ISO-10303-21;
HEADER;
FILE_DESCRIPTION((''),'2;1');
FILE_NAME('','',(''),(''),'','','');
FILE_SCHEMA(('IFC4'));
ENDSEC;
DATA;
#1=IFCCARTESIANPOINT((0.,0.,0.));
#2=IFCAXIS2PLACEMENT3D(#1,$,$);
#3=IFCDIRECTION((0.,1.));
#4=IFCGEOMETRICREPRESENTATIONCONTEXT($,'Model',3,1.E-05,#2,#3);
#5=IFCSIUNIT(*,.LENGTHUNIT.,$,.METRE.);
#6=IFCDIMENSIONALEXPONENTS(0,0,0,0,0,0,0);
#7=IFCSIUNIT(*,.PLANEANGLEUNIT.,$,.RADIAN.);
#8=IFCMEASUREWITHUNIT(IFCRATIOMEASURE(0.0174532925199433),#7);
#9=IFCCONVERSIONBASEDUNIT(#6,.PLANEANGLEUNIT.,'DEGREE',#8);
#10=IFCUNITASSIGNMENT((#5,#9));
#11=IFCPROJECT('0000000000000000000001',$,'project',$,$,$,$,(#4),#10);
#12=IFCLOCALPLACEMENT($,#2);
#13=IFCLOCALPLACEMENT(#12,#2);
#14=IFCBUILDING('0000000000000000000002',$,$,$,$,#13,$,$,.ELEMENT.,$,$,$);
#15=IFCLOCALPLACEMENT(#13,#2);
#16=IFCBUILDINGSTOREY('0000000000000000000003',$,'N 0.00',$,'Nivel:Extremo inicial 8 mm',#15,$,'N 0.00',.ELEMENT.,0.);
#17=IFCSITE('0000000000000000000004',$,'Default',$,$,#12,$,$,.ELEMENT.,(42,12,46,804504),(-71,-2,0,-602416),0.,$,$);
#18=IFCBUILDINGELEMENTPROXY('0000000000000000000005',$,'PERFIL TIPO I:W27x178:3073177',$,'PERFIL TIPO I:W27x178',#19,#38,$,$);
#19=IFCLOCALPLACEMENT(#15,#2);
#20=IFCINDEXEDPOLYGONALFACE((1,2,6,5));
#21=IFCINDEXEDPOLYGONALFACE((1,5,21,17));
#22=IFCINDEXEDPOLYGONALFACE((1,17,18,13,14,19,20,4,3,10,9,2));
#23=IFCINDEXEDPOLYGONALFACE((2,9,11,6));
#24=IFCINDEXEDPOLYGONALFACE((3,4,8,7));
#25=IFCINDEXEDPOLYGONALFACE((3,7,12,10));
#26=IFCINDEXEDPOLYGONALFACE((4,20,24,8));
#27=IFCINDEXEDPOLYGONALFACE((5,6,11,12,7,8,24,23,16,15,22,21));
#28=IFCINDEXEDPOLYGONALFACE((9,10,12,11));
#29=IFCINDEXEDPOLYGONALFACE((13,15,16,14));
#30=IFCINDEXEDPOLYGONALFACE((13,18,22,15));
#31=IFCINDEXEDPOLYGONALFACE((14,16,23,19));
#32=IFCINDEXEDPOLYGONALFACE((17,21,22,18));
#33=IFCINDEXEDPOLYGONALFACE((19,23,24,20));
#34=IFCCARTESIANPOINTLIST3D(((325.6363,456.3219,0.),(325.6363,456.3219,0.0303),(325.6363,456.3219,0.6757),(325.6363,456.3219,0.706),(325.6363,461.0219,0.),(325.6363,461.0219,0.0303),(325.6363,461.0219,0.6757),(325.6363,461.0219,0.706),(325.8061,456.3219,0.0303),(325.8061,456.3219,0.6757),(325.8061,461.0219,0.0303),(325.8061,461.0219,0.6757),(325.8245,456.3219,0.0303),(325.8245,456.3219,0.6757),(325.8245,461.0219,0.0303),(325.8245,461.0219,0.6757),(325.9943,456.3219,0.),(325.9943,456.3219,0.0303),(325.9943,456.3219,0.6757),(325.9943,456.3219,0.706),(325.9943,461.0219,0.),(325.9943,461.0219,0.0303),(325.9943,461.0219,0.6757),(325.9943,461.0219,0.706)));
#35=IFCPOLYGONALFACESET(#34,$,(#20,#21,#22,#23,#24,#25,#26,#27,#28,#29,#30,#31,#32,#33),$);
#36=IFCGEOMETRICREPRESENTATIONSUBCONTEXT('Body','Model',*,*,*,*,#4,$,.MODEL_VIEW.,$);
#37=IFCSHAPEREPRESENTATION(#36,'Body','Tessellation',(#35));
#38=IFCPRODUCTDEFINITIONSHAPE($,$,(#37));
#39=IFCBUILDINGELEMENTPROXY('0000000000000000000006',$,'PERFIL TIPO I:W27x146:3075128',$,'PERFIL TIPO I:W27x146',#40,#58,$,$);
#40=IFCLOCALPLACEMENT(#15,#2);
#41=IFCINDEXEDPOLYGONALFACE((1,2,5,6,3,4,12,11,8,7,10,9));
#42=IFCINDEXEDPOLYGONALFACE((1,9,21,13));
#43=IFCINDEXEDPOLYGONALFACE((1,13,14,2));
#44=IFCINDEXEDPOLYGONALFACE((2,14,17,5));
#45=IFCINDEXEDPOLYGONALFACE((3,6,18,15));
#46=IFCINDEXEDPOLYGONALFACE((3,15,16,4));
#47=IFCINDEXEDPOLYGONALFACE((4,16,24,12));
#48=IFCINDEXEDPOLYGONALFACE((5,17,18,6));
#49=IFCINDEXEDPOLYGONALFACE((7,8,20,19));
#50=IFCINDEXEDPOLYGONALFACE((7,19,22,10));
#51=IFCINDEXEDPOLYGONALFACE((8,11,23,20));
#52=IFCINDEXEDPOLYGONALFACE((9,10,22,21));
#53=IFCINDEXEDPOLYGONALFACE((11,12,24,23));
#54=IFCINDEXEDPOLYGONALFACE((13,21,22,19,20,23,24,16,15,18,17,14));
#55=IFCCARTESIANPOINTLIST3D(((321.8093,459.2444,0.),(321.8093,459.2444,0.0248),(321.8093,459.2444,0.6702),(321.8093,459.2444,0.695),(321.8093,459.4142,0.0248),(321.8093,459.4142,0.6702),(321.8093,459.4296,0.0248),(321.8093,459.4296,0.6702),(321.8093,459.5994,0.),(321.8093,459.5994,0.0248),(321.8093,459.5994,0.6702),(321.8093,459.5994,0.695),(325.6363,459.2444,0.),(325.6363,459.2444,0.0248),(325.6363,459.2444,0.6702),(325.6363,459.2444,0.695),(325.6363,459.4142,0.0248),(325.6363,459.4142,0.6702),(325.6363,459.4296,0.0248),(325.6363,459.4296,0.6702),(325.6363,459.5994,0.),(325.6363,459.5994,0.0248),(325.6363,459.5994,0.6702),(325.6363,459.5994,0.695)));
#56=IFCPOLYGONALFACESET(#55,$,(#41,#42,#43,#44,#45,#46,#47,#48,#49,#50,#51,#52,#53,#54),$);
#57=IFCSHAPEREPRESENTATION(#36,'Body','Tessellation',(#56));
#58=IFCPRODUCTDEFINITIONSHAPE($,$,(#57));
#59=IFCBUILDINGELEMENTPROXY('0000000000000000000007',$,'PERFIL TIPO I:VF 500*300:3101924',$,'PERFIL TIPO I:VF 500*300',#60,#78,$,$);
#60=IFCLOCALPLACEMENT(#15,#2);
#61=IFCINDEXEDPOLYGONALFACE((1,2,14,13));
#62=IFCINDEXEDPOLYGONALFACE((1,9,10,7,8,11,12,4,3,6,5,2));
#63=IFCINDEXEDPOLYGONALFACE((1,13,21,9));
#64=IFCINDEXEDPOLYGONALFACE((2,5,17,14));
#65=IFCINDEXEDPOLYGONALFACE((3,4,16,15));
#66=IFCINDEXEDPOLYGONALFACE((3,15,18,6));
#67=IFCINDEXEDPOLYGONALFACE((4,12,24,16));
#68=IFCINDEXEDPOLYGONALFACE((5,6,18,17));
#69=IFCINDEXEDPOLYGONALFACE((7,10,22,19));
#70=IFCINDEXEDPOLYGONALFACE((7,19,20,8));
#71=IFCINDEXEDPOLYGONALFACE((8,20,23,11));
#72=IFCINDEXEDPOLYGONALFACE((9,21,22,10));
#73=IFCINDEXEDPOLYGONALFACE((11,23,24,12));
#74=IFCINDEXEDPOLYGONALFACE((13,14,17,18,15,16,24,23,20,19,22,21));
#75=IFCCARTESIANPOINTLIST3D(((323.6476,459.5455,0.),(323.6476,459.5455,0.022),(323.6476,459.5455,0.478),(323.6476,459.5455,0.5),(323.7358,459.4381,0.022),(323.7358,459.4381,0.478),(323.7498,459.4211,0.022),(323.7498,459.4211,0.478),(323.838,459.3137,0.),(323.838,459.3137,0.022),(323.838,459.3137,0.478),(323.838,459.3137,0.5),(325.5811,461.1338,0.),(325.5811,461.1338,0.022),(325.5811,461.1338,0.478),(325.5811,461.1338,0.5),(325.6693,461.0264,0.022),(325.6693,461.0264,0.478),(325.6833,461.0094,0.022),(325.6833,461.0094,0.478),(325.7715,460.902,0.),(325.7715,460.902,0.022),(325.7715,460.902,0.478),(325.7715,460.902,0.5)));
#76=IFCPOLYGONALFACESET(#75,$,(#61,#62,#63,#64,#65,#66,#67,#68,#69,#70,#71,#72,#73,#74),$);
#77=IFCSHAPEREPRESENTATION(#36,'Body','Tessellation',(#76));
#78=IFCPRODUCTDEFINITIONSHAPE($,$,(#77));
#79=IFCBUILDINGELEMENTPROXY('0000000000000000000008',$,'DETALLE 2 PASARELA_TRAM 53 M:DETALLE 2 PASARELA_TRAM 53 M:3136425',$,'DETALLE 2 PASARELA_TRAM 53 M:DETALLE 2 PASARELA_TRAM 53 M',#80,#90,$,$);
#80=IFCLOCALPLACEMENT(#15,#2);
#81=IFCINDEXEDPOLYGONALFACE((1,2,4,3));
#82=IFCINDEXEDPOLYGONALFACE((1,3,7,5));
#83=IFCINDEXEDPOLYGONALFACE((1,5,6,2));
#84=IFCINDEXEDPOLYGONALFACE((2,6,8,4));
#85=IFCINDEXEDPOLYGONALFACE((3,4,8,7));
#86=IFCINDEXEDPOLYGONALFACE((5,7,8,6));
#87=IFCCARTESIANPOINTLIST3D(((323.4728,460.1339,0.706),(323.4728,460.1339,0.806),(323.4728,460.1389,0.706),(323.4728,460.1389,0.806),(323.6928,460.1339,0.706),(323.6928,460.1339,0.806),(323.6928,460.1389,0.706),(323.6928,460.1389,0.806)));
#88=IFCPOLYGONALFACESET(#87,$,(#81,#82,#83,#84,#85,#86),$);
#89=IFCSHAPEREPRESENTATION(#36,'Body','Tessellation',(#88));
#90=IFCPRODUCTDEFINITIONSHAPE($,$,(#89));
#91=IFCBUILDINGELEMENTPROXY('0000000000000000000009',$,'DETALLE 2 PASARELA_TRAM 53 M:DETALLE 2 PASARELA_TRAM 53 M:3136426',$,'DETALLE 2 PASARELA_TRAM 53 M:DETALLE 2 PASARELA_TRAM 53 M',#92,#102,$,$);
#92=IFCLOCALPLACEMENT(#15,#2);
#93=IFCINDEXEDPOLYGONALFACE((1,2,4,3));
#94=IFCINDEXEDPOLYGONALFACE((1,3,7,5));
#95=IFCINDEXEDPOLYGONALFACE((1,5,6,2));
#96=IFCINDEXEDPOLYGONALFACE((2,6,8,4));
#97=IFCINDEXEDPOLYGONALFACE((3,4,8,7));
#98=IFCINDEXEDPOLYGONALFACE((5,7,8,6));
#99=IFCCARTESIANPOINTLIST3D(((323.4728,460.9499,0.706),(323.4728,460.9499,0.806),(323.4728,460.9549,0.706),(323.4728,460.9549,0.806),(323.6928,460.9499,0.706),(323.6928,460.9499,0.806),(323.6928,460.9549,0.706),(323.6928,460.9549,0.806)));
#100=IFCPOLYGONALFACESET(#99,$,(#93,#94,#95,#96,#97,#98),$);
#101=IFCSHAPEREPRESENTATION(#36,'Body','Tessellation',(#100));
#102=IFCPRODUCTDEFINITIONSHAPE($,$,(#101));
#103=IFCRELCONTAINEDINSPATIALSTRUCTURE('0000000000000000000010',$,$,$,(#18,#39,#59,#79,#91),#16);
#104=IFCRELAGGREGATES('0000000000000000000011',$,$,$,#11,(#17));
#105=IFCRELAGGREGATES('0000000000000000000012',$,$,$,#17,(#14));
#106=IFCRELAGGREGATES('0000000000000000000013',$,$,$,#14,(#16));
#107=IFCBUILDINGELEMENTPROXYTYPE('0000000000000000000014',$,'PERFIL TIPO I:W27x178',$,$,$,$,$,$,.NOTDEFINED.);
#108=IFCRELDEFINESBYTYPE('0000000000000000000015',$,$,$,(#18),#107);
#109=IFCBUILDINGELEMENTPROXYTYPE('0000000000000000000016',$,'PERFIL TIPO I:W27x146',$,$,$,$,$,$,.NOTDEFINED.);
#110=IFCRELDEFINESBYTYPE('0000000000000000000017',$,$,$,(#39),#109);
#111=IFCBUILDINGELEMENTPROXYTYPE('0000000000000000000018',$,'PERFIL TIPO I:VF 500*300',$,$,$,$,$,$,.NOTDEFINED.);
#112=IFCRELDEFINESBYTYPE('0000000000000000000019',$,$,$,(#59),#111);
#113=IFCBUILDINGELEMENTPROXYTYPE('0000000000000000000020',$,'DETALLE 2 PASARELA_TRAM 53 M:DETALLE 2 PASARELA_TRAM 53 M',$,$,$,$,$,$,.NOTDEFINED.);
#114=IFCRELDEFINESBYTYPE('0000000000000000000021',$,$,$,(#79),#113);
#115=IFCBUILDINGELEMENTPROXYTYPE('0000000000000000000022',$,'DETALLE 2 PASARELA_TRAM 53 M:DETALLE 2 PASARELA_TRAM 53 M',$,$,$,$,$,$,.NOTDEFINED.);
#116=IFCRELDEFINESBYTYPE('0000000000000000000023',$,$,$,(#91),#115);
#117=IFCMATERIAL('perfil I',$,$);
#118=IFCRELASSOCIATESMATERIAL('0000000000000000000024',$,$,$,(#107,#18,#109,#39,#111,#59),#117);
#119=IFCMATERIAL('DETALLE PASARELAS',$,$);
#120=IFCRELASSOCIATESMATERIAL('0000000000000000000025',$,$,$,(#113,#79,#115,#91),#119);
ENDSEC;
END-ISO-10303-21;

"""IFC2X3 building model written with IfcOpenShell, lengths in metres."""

from ifc_helpers import new_model, entity, si_unit, converted_unit, direction, frame, frame_2d, origin, place, context, subcontext, project, spatial, polyline, rectangle, outline, extrude, source, transform, mapped, material, type_object, type_shapes, element, save


model = new_model("IFC2X3")

# Units and contexts
model_context = context("Model", 3, precision=1e-05, world=origin(), true_north=direction((0.0, 1.0)))
body_context = subcontext(model_context, "Body", "Model", "MODEL_VIEW")
ifc_project = project(units=[si_unit("LENGTHUNIT", "METRE"), converted_unit("PLANEANGLEUNIT", "DEGREE", entity("IfcRatioMeasure", 0.0174532925199433), si_unit("PLANEANGLEUNIT", "RADIAN"), dimensions=[0, 0, 0, 0, 0, 0, 0])], contexts=[model_context])

# Site, building, storey
site_placement = place(None, origin())
site = spatial("IfcSite", under=ifc_project, at=site_placement, Name="Default", CompositionType="ELEMENT", RefLatitude=(42, 12, 46, 804504), RefLongitude=(-71, -2, 0, -602416), RefElevation=0.0)
building_placement = place(site_placement, origin())
building = spatial("IfcBuilding", under=site, at=building_placement, CompositionType="ELEMENT")
storey_placement = place(building_placement, origin())
storey = spatial("IfcBuildingStorey", under=building, at=storey_placement, Name="N 0.00", ObjectType="Nivel:Extremo inicial 8 mm", LongName="N 0.00", CompositionType="ELEMENT", Elevation=0.0)

# Building element proxies
ifc_material_1 = material(Name="perfil I")
building_element_proxy_type_1 = type_object("IfcBuildingElementProxyType", Name="PERFIL TIPO I:W27x178", PredefinedType="NOTDEFINED", material=ifc_material_1)
shared_shape_1 = source(origin(), body_context, "Body", "SweptSolid", [
    extrude(outline(polyline([(-0.179, -0.3227), (-0.179, -0.353), (0.179, -0.353), (0.179, -0.3227), (0.0092, -0.3227), (0.0092, 0.3227), (0.179, 0.3227), (0.179, 0.353), (-0.179, 0.353), (-0.179, 0.3227), (-0.0092, 0.3227), (-0.0092, -0.3227), (-0.179, -0.3227)])), frame((0.0, 0.0, 0.353), z_axis=(-1.0, 0.0, 0.0), x_axis=(0.0, 1.0, 0.0)), (0.0, 0.0, -1.0), 4.7),
])
type_shapes(building_element_proxy_type_1, [shared_shape_1])
proxy_1_placement = place(storey_placement, frame((325.8153, 461.0219, 0.0), z_axis=(0.0, 0.0, 1.0), x_axis=(0.0, -1.0, 0.0)))
element("IfcBuildingElementProxy", 1, at=proxy_1_placement, inside=storey, type_object=building_element_proxy_type_1, material=ifc_material_1, Name="PERFIL TIPO I:W27x178:3073177", ObjectType="PERFIL TIPO I:W27x178", context=body_context, shape_type="MappedRepresentation", body=[
    mapped(shared_shape_1, transform((0.0, 0.0, 0.0), scale=1.0)),
])
building_element_proxy_type_2 = type_object("IfcBuildingElementProxyType", Name="PERFIL TIPO I:W27x146", PredefinedType="NOTDEFINED", material=ifc_material_1)
shared_shape_2 = source(origin(), body_context, "Body", "SweptSolid", [
    extrude(outline(polyline([(0.3227, -0.1775), (0.3475, -0.1775), (0.3475, 0.1775), (0.3227, 0.1775), (0.3227, 0.0077), (-0.3227, 0.0077), (-0.3227, 0.1775), (-0.3475, 0.1775), (-0.3475, -0.1775), (-0.3227, -0.1775), (-0.3227, -0.0077), (0.3227, -0.0077), (0.3227, -0.1775)])), frame((0.0, 0.0, 0.3475), z_axis=(1.0, 0.0, 0.0), x_axis=(0.0, 0.0, 1.0)), (0.0, 0.0, 1.0), 3.827),
])
type_shapes(building_element_proxy_type_2, [shared_shape_2])
proxy_2_placement = place(storey_placement, frame((321.8093, 459.4219, 0.0)))
element("IfcBuildingElementProxy", 2, at=proxy_2_placement, inside=storey, type_object=building_element_proxy_type_2, material=ifc_material_1, Name="PERFIL TIPO I:W27x146:3075128", ObjectType="PERFIL TIPO I:W27x146", context=body_context, shape_type="MappedRepresentation", body=[
    mapped(shared_shape_2, transform((0.0, 0.0, 0.0), scale=1.0)),
])
building_element_proxy_type_3 = type_object("IfcBuildingElementProxyType", Name="PERFIL TIPO I:VF 500*300", PredefinedType="NOTDEFINED", material=ifc_material_1)
shared_shape_3 = source(origin(), body_context, "Body", "SweptSolid", [
    extrude(outline(polyline([(0.228, -0.15), (0.25, -0.15), (0.25, 0.15), (0.228, 0.15), (0.228, 0.011), (-0.228, 0.011), (-0.228, 0.15), (-0.25, 0.15), (-0.25, -0.15), (-0.228, -0.15), (-0.228, -0.011), (0.228, -0.011), (0.228, -0.15)])), frame((0.0, 0.0, 0.25), z_axis=(1.0, 0.0, 0.0), x_axis=(0.0, 0.0, 1.0)), (0.0, 0.0, 1.0), 2.5022),
])
type_shapes(building_element_proxy_type_3, [shared_shape_3])
proxy_3_placement = place(storey_placement, frame((323.7428, 459.4296, 0.0), z_axis=(0.0, 0.0, 1.0), x_axis=(0.772718, 0.63475, 0.0)))
element("IfcBuildingElementProxy", 3, at=proxy_3_placement, inside=storey, type_object=building_element_proxy_type_3, material=ifc_material_1, Name="PERFIL TIPO I:VF 500*300:3101924", ObjectType="PERFIL TIPO I:VF 500*300", context=body_context, shape_type="MappedRepresentation", body=[
    mapped(shared_shape_3, transform((0.0, 0.0, 0.0), scale=1.0)),
])
ifc_material_2 = material(Name="DETALLE PASARELAS")
building_element_proxy_type_4 = type_object("IfcBuildingElementProxyType", Name="DETALLE 2 PASARELA_TRAM 53 M:DETALLE 2 PASARELA_TRAM 53 M", PredefinedType="NOTDEFINED", material=ifc_material_2)
shared_shape_4 = source(origin(), body_context, "Body", "SweptSolid", [
    extrude(rectangle(XDim=0.22, YDim=0.005, at=frame_2d((0.0, 0.0), x_axis=(1.0, 0.0))), frame((0.11, 0.0475, 0.0), z_axis=(0.0, 0.0, 1.0), x_axis=(-1.0, 0.0, 0.0)), (0.0, 0.0, 1.0), 0.1),
])
type_shapes(building_element_proxy_type_4, [shared_shape_4])
proxy_4_placement = place(storey_placement, frame((323.4728, 460.0889, 0.706)))
element("IfcBuildingElementProxy", 4, at=proxy_4_placement, inside=storey, type_object=building_element_proxy_type_4, material=ifc_material_2, Name="DETALLE 2 PASARELA_TRAM 53 M:DETALLE 2 PASARELA_TRAM 53 M:3136425", ObjectType="DETALLE 2 PASARELA_TRAM 53 M:DETALLE 2 PASARELA_TRAM 53 M", context=body_context, shape_type="MappedRepresentation", body=[
    mapped(shared_shape_4, transform((0.0, 0.0, 0.0), scale=1.0)),
])
building_element_proxy_type_5 = type_object("IfcBuildingElementProxyType", Name="DETALLE 2 PASARELA_TRAM 53 M:DETALLE 2 PASARELA_TRAM 53 M", PredefinedType="NOTDEFINED", material=ifc_material_2)
shared_shape_5 = source(origin(), body_context, "Body", "SweptSolid", [
    extrude(rectangle(XDim=0.005, YDim=0.22, at=frame_2d((0.0, 0.0), x_axis=(1.0, 0.0))), frame((0.11, -0.0475, 0.0), z_axis=(0.0, 0.0, 1.0), x_axis=(0.0, 1.0, 0.0)), (0.0, 0.0, 1.0), 0.1),
])
type_shapes(building_element_proxy_type_5, [shared_shape_5])
proxy_5_placement = place(storey_placement, frame((323.4728, 460.9999, 0.706)))
element("IfcBuildingElementProxy", 5, at=proxy_5_placement, inside=storey, type_object=building_element_proxy_type_5, material=ifc_material_2, Name="DETALLE 2 PASARELA_TRAM 53 M:DETALLE 2 PASARELA_TRAM 53 M:3136426", ObjectType="DETALLE 2 PASARELA_TRAM 53 M:DETALLE 2 PASARELA_TRAM 53 M", context=body_context, shape_type="MappedRepresentation", body=[
    mapped(shared_shape_5, transform((0.0, 0.0, 0.0), scale=1.0)),
])

save(model, "model.ifc")
